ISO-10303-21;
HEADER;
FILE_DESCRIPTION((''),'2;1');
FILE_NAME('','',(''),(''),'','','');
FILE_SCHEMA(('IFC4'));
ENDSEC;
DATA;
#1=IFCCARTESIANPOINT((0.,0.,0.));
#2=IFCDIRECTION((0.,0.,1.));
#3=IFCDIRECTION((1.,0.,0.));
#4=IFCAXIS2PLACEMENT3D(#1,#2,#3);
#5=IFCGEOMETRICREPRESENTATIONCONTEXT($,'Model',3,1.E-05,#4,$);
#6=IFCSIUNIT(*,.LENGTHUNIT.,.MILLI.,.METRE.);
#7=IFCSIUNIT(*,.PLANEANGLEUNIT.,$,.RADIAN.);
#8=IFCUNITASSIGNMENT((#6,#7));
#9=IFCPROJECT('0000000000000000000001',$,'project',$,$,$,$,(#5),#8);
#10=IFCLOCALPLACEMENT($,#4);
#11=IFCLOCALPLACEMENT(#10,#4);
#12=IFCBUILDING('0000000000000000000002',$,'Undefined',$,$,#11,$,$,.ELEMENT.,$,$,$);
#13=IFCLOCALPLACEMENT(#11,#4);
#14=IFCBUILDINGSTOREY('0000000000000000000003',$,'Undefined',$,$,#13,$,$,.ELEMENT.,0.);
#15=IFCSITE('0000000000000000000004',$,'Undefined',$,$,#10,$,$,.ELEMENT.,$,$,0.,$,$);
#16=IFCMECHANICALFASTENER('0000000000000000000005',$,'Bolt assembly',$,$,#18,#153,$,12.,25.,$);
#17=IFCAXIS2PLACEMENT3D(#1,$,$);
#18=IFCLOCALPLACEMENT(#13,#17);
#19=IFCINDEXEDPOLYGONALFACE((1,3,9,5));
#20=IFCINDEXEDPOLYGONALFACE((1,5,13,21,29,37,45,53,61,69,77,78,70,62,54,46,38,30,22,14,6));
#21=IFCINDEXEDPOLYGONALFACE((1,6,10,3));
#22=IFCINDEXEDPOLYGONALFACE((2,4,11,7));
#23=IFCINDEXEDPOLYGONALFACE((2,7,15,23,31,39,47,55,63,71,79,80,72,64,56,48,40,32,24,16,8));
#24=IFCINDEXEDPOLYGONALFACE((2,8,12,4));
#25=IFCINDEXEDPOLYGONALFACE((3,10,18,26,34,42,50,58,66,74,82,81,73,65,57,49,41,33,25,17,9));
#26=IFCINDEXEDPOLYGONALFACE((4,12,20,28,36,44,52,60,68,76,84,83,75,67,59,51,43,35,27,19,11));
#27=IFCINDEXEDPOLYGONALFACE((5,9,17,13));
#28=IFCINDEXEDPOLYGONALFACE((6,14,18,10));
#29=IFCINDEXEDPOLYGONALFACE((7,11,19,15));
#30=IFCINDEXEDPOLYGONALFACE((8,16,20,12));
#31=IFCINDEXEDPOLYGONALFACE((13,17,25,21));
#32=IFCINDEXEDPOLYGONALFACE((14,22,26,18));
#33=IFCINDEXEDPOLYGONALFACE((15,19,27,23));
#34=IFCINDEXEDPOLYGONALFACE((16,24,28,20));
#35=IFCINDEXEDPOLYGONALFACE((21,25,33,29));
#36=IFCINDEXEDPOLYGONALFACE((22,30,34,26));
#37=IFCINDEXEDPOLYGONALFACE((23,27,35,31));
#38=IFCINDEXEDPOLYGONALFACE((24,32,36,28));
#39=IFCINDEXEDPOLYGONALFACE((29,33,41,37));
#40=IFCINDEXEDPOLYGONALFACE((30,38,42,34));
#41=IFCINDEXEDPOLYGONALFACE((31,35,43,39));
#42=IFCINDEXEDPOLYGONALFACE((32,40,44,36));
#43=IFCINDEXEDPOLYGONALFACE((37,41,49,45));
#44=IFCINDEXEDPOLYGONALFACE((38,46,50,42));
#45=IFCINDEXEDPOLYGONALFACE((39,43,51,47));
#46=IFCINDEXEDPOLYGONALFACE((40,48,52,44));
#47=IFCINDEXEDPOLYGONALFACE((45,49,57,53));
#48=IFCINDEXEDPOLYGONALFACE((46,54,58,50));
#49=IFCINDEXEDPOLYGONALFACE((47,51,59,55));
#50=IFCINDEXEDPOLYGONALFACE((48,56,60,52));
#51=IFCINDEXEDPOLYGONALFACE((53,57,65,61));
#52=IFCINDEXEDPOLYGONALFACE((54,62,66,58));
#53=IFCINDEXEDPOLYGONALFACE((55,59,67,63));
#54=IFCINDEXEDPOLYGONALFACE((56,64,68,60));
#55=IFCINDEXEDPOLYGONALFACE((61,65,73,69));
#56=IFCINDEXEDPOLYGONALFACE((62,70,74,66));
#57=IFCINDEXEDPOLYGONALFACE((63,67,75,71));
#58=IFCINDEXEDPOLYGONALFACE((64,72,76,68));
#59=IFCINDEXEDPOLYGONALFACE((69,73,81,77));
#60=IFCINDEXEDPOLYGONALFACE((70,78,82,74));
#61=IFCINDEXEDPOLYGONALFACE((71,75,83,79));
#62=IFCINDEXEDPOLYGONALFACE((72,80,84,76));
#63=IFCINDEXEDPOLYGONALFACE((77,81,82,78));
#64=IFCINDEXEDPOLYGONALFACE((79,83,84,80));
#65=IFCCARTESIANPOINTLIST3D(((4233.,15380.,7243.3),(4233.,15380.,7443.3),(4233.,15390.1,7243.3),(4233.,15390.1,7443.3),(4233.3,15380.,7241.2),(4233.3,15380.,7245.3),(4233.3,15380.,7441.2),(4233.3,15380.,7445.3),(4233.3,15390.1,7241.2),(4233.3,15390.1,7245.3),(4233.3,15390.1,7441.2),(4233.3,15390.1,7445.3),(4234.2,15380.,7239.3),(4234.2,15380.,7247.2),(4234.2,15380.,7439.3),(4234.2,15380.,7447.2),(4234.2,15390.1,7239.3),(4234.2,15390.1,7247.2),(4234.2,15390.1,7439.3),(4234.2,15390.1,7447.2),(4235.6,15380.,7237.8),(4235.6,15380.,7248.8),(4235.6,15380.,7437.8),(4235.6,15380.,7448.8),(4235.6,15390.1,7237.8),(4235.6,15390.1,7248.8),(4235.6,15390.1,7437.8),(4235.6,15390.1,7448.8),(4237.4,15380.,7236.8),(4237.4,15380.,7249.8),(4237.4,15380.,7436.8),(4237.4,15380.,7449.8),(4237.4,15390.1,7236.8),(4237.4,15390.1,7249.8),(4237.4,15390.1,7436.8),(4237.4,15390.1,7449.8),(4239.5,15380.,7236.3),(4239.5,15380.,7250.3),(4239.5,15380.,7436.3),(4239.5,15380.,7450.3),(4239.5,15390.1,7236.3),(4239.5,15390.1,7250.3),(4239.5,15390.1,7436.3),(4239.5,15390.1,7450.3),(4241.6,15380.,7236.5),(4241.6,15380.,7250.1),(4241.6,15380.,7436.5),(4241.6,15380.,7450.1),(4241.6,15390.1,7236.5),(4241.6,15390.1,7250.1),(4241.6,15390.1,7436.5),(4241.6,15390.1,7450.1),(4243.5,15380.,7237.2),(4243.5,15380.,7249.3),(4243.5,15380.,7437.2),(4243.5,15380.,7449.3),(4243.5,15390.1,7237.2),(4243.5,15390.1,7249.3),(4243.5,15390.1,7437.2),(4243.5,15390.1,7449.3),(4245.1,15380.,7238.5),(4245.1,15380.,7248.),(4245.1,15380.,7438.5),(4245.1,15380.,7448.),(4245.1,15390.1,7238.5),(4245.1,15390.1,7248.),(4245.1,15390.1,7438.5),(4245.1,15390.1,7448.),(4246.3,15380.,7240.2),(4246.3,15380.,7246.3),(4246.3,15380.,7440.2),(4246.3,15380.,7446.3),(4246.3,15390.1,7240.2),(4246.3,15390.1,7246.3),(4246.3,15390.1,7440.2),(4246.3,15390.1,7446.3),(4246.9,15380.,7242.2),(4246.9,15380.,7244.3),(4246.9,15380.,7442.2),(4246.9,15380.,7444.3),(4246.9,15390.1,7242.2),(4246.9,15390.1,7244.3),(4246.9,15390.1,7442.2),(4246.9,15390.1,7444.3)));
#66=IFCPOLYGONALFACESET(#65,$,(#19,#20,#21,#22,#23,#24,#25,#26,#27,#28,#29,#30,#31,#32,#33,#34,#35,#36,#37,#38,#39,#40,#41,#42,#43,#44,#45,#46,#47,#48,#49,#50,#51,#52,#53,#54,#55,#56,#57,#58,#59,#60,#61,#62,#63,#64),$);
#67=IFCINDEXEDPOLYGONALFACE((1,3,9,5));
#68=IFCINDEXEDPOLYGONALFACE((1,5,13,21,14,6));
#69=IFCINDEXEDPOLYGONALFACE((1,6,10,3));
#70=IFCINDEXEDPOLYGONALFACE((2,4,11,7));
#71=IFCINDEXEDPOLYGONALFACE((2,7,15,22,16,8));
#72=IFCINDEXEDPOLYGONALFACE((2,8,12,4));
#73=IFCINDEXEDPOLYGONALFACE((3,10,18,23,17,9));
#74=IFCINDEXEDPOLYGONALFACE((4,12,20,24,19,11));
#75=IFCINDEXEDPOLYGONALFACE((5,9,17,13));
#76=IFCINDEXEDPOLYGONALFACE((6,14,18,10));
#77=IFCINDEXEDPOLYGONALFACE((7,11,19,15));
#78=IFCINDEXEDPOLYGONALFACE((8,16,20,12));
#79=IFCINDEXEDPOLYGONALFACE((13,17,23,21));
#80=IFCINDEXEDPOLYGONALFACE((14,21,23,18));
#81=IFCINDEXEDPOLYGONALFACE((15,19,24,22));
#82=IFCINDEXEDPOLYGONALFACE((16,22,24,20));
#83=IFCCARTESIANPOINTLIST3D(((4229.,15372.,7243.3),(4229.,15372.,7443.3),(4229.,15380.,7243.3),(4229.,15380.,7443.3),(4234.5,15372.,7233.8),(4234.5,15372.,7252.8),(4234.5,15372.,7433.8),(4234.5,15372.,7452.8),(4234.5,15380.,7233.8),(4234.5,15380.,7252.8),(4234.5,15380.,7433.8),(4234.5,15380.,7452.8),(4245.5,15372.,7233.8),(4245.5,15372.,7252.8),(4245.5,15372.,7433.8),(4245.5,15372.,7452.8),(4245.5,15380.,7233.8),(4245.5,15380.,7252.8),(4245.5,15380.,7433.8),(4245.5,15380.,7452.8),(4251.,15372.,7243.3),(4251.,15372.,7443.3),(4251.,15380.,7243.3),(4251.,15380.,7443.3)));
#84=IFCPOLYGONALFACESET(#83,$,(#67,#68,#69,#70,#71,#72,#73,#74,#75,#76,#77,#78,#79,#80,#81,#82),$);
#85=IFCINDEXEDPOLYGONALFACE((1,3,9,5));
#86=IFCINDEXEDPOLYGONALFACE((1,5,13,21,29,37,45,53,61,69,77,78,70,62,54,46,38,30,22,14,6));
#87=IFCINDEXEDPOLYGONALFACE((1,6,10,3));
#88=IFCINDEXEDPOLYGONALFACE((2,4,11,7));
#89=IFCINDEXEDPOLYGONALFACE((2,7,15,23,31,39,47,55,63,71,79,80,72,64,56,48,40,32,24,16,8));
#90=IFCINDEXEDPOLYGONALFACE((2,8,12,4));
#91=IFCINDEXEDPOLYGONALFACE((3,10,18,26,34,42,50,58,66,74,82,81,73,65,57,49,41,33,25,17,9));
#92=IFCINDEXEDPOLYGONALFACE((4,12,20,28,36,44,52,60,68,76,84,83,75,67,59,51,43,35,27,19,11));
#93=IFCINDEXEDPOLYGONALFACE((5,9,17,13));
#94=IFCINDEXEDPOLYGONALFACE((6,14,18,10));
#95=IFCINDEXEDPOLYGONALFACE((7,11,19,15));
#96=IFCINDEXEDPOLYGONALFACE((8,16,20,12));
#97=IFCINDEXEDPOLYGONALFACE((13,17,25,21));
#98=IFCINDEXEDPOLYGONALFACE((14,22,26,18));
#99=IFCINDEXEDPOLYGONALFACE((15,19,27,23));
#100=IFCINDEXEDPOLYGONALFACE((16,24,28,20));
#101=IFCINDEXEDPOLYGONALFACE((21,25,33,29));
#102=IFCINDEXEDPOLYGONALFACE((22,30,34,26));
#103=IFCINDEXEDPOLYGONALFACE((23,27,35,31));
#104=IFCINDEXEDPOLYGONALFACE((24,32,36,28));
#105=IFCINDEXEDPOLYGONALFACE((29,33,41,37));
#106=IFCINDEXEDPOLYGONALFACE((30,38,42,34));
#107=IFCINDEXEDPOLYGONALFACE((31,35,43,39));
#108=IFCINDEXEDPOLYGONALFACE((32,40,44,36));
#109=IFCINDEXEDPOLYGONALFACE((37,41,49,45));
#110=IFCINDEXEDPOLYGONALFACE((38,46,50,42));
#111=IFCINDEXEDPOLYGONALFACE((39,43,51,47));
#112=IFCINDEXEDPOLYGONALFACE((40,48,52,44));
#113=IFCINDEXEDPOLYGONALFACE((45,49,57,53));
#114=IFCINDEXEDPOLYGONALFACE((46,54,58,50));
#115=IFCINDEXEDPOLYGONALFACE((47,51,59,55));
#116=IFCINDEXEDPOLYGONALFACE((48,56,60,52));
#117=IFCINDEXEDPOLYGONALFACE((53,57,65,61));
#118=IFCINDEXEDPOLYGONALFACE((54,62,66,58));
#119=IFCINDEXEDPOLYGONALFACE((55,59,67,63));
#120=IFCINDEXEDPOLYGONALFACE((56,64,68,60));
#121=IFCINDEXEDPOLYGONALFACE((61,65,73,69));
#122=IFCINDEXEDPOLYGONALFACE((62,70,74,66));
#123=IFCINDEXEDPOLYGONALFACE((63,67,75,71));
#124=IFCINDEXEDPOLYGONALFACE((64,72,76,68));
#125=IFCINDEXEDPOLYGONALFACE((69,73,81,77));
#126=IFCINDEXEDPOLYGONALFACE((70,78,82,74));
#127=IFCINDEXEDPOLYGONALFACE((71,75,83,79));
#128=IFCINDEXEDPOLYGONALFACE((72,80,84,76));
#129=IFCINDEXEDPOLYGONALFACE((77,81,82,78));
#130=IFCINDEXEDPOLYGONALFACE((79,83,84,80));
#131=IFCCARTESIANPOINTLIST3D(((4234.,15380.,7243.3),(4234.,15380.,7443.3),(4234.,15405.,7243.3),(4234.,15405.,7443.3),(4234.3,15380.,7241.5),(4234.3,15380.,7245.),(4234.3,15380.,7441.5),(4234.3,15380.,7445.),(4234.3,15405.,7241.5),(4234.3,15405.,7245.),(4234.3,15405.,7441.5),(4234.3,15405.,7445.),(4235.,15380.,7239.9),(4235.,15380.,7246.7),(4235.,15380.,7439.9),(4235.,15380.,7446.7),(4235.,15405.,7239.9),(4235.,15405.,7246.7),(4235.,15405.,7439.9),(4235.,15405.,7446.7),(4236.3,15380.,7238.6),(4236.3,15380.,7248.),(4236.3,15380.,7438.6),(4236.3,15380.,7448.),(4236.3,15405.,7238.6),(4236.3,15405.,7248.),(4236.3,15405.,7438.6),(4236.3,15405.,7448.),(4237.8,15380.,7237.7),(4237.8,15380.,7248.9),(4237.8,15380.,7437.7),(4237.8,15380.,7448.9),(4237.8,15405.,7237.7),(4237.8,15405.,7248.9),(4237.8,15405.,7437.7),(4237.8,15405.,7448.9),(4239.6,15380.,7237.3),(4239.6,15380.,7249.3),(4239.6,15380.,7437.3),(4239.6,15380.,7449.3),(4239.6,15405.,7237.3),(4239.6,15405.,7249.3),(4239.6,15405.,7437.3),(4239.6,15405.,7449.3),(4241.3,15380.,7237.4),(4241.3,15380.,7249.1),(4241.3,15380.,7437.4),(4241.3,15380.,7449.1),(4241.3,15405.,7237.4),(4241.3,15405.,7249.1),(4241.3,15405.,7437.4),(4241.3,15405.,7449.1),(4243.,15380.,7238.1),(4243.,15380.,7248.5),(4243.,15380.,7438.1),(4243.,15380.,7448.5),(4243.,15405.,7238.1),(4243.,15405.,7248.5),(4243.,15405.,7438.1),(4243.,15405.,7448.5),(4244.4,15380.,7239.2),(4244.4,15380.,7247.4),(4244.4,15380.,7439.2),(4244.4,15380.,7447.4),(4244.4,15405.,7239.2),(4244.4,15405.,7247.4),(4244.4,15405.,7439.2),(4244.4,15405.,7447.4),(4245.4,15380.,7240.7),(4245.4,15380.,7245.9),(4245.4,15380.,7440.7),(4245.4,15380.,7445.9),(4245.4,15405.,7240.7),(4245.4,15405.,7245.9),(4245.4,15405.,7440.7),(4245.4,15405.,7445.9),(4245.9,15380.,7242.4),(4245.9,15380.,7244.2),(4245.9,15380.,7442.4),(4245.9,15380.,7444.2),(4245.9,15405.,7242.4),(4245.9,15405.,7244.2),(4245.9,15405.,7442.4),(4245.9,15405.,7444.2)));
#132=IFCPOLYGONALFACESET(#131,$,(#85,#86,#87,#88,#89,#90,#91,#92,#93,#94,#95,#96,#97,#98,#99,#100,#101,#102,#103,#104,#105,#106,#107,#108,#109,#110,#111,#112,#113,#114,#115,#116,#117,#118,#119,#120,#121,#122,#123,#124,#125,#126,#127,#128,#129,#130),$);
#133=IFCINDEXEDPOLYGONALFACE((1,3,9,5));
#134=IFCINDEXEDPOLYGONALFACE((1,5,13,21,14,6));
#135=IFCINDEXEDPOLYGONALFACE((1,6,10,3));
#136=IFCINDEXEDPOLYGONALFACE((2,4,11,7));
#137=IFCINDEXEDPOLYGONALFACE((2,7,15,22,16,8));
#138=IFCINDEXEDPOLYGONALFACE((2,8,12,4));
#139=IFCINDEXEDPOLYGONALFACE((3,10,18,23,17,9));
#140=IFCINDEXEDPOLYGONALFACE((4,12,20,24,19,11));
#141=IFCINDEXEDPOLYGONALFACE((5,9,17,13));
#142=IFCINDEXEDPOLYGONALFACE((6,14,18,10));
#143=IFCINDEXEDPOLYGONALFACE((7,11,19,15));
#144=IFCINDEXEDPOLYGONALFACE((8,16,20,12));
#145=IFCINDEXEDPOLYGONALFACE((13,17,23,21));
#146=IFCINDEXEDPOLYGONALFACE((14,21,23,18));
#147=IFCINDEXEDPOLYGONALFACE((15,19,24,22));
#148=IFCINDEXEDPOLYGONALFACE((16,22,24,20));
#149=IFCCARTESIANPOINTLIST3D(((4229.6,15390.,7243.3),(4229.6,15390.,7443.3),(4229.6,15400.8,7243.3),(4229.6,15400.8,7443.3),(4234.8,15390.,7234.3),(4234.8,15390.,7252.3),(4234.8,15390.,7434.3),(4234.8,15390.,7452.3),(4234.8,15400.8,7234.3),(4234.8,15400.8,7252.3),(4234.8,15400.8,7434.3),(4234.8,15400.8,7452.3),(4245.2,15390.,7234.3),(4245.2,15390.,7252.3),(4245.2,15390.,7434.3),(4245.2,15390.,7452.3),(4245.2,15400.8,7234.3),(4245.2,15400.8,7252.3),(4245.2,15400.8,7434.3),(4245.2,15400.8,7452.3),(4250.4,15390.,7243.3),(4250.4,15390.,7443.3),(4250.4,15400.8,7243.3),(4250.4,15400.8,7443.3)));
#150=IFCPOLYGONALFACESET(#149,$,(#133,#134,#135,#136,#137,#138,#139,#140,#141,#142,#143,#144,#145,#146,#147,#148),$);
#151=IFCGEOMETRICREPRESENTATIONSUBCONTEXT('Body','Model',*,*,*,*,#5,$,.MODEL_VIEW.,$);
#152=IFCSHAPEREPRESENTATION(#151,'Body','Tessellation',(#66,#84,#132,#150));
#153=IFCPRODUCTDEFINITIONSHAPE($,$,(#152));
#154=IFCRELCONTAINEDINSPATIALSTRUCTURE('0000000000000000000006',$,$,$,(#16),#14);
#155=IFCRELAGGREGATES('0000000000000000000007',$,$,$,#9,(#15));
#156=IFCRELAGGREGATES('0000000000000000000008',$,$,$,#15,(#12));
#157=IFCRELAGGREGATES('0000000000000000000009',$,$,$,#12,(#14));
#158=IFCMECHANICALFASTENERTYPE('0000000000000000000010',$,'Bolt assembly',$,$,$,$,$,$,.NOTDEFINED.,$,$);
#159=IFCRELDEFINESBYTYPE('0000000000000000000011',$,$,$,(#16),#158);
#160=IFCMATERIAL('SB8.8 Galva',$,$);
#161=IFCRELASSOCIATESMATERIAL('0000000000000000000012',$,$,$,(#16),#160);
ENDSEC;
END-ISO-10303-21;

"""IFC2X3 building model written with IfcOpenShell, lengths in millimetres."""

from ifc_helpers import new_model, si_unit, frame, origin_with_axes, origin_2d_with_axis, place, context, subcontext, project, spatial, polyline, circle, outline, extrude, source, transform, mapped, material, type_object, element, save


model = new_model("IFC2X3")

# Units and contexts
model_context = context("Model", 3, precision=1e-05, world=origin_with_axes())
body_context = subcontext(model_context, "Body", "Model", "MODEL_VIEW")
ifc_project = project(units=[si_unit("LENGTHUNIT", "METRE", prefix="MILLI"), si_unit("PLANEANGLEUNIT", "RADIAN")], contexts=[model_context])

# Site, building, storey
site_placement = place(None, origin_with_axes())
site = spatial("IfcSite", under=ifc_project, at=site_placement, Name="Undefined", CompositionType="ELEMENT", RefElevation=0.0)
building_placement = place(site_placement, origin_with_axes())
building = spatial("IfcBuilding", under=site, at=building_placement, Name="Undefined", CompositionType="ELEMENT")
storey_placement = place(building_placement, origin_with_axes())
storey = spatial("IfcBuildingStorey", under=building, at=storey_placement, Name="Undefined", CompositionType="ELEMENT", Elevation=0.0)

# Mechanical fastener
mechanical_fastener_type = type_object("IfcMechanicalFastenerType", Name="Bolt assembly")
ifc_material_1 = material(Name="SB8.8 Galva")
shared_shape_1 = source(origin_with_axes(), body_context, "Body", "SweptSolid", [
    extrude(circle(Radius=7.0, at=origin_2d_with_axis()), frame((0.0, -10.0, 0.0), z_axis=(0.0, 1.0, 0.0), x_axis=(1.0, 0.0, 0.0)), (0.0, 0.0, 1.0), 10.1),
    extrude(outline(polyline([(11.0, 0.0), (5.5, 9.5), (-5.5, 9.5), (-11.0, 0.0), (-5.5, -9.5), (5.5, -9.5), (11.0, 0.0)])), frame((0.0, -18.0, 0.0), z_axis=(0.0, 1.0, 0.0), x_axis=(1.0, 0.0, 0.0)), (0.0, 0.0, 1.0), 8.0),
    extrude(circle(Radius=6.0, at=origin_2d_with_axis()), frame((0.0, -10.0, 0.0), z_axis=(0.0, 1.0, 0.0), x_axis=(1.0, 0.0, 0.0)), (0.0, 0.0, 1.0), 25.0),
    extrude(outline(polyline([(10.4, 0.0), (5.2, 9.0), (-5.2, 9.0), (-10.4, 0.0), (-5.2, -9.0), (5.2, -9.0), (10.4, 0.0)])), frame((0.0, 0.0, 0.0), z_axis=(0.0, 1.0, 0.0), x_axis=(1.0, 0.0, 0.0)), (0.0, 0.0, 1.0), 10.8),
])
for number, where, z_axis, x_axis, name in (
    (1, (4240.0, 15390.0, 7343.3), (0.0, 0.0, -1.0), (-1.0, 0.0, 0.0), "Bolt assembly"),
):
    element("IfcMechanicalFastener", number, at=place(storey_placement, frame(where, z_axis=z_axis, x_axis=x_axis)), inside=storey, type_object=mechanical_fastener_type, material=ifc_material_1, Name=name, NominalDiameter=12.0, NominalLength=25.0, context=body_context, shape_type="MappedRepresentation", body=[
        mapped(shared_shape_1, transform((0.0, 0.0, -100.0))),
        mapped(shared_shape_1, transform((0.0, 0.0, 100.0))),
    ])

save(model, "model.ifc")
